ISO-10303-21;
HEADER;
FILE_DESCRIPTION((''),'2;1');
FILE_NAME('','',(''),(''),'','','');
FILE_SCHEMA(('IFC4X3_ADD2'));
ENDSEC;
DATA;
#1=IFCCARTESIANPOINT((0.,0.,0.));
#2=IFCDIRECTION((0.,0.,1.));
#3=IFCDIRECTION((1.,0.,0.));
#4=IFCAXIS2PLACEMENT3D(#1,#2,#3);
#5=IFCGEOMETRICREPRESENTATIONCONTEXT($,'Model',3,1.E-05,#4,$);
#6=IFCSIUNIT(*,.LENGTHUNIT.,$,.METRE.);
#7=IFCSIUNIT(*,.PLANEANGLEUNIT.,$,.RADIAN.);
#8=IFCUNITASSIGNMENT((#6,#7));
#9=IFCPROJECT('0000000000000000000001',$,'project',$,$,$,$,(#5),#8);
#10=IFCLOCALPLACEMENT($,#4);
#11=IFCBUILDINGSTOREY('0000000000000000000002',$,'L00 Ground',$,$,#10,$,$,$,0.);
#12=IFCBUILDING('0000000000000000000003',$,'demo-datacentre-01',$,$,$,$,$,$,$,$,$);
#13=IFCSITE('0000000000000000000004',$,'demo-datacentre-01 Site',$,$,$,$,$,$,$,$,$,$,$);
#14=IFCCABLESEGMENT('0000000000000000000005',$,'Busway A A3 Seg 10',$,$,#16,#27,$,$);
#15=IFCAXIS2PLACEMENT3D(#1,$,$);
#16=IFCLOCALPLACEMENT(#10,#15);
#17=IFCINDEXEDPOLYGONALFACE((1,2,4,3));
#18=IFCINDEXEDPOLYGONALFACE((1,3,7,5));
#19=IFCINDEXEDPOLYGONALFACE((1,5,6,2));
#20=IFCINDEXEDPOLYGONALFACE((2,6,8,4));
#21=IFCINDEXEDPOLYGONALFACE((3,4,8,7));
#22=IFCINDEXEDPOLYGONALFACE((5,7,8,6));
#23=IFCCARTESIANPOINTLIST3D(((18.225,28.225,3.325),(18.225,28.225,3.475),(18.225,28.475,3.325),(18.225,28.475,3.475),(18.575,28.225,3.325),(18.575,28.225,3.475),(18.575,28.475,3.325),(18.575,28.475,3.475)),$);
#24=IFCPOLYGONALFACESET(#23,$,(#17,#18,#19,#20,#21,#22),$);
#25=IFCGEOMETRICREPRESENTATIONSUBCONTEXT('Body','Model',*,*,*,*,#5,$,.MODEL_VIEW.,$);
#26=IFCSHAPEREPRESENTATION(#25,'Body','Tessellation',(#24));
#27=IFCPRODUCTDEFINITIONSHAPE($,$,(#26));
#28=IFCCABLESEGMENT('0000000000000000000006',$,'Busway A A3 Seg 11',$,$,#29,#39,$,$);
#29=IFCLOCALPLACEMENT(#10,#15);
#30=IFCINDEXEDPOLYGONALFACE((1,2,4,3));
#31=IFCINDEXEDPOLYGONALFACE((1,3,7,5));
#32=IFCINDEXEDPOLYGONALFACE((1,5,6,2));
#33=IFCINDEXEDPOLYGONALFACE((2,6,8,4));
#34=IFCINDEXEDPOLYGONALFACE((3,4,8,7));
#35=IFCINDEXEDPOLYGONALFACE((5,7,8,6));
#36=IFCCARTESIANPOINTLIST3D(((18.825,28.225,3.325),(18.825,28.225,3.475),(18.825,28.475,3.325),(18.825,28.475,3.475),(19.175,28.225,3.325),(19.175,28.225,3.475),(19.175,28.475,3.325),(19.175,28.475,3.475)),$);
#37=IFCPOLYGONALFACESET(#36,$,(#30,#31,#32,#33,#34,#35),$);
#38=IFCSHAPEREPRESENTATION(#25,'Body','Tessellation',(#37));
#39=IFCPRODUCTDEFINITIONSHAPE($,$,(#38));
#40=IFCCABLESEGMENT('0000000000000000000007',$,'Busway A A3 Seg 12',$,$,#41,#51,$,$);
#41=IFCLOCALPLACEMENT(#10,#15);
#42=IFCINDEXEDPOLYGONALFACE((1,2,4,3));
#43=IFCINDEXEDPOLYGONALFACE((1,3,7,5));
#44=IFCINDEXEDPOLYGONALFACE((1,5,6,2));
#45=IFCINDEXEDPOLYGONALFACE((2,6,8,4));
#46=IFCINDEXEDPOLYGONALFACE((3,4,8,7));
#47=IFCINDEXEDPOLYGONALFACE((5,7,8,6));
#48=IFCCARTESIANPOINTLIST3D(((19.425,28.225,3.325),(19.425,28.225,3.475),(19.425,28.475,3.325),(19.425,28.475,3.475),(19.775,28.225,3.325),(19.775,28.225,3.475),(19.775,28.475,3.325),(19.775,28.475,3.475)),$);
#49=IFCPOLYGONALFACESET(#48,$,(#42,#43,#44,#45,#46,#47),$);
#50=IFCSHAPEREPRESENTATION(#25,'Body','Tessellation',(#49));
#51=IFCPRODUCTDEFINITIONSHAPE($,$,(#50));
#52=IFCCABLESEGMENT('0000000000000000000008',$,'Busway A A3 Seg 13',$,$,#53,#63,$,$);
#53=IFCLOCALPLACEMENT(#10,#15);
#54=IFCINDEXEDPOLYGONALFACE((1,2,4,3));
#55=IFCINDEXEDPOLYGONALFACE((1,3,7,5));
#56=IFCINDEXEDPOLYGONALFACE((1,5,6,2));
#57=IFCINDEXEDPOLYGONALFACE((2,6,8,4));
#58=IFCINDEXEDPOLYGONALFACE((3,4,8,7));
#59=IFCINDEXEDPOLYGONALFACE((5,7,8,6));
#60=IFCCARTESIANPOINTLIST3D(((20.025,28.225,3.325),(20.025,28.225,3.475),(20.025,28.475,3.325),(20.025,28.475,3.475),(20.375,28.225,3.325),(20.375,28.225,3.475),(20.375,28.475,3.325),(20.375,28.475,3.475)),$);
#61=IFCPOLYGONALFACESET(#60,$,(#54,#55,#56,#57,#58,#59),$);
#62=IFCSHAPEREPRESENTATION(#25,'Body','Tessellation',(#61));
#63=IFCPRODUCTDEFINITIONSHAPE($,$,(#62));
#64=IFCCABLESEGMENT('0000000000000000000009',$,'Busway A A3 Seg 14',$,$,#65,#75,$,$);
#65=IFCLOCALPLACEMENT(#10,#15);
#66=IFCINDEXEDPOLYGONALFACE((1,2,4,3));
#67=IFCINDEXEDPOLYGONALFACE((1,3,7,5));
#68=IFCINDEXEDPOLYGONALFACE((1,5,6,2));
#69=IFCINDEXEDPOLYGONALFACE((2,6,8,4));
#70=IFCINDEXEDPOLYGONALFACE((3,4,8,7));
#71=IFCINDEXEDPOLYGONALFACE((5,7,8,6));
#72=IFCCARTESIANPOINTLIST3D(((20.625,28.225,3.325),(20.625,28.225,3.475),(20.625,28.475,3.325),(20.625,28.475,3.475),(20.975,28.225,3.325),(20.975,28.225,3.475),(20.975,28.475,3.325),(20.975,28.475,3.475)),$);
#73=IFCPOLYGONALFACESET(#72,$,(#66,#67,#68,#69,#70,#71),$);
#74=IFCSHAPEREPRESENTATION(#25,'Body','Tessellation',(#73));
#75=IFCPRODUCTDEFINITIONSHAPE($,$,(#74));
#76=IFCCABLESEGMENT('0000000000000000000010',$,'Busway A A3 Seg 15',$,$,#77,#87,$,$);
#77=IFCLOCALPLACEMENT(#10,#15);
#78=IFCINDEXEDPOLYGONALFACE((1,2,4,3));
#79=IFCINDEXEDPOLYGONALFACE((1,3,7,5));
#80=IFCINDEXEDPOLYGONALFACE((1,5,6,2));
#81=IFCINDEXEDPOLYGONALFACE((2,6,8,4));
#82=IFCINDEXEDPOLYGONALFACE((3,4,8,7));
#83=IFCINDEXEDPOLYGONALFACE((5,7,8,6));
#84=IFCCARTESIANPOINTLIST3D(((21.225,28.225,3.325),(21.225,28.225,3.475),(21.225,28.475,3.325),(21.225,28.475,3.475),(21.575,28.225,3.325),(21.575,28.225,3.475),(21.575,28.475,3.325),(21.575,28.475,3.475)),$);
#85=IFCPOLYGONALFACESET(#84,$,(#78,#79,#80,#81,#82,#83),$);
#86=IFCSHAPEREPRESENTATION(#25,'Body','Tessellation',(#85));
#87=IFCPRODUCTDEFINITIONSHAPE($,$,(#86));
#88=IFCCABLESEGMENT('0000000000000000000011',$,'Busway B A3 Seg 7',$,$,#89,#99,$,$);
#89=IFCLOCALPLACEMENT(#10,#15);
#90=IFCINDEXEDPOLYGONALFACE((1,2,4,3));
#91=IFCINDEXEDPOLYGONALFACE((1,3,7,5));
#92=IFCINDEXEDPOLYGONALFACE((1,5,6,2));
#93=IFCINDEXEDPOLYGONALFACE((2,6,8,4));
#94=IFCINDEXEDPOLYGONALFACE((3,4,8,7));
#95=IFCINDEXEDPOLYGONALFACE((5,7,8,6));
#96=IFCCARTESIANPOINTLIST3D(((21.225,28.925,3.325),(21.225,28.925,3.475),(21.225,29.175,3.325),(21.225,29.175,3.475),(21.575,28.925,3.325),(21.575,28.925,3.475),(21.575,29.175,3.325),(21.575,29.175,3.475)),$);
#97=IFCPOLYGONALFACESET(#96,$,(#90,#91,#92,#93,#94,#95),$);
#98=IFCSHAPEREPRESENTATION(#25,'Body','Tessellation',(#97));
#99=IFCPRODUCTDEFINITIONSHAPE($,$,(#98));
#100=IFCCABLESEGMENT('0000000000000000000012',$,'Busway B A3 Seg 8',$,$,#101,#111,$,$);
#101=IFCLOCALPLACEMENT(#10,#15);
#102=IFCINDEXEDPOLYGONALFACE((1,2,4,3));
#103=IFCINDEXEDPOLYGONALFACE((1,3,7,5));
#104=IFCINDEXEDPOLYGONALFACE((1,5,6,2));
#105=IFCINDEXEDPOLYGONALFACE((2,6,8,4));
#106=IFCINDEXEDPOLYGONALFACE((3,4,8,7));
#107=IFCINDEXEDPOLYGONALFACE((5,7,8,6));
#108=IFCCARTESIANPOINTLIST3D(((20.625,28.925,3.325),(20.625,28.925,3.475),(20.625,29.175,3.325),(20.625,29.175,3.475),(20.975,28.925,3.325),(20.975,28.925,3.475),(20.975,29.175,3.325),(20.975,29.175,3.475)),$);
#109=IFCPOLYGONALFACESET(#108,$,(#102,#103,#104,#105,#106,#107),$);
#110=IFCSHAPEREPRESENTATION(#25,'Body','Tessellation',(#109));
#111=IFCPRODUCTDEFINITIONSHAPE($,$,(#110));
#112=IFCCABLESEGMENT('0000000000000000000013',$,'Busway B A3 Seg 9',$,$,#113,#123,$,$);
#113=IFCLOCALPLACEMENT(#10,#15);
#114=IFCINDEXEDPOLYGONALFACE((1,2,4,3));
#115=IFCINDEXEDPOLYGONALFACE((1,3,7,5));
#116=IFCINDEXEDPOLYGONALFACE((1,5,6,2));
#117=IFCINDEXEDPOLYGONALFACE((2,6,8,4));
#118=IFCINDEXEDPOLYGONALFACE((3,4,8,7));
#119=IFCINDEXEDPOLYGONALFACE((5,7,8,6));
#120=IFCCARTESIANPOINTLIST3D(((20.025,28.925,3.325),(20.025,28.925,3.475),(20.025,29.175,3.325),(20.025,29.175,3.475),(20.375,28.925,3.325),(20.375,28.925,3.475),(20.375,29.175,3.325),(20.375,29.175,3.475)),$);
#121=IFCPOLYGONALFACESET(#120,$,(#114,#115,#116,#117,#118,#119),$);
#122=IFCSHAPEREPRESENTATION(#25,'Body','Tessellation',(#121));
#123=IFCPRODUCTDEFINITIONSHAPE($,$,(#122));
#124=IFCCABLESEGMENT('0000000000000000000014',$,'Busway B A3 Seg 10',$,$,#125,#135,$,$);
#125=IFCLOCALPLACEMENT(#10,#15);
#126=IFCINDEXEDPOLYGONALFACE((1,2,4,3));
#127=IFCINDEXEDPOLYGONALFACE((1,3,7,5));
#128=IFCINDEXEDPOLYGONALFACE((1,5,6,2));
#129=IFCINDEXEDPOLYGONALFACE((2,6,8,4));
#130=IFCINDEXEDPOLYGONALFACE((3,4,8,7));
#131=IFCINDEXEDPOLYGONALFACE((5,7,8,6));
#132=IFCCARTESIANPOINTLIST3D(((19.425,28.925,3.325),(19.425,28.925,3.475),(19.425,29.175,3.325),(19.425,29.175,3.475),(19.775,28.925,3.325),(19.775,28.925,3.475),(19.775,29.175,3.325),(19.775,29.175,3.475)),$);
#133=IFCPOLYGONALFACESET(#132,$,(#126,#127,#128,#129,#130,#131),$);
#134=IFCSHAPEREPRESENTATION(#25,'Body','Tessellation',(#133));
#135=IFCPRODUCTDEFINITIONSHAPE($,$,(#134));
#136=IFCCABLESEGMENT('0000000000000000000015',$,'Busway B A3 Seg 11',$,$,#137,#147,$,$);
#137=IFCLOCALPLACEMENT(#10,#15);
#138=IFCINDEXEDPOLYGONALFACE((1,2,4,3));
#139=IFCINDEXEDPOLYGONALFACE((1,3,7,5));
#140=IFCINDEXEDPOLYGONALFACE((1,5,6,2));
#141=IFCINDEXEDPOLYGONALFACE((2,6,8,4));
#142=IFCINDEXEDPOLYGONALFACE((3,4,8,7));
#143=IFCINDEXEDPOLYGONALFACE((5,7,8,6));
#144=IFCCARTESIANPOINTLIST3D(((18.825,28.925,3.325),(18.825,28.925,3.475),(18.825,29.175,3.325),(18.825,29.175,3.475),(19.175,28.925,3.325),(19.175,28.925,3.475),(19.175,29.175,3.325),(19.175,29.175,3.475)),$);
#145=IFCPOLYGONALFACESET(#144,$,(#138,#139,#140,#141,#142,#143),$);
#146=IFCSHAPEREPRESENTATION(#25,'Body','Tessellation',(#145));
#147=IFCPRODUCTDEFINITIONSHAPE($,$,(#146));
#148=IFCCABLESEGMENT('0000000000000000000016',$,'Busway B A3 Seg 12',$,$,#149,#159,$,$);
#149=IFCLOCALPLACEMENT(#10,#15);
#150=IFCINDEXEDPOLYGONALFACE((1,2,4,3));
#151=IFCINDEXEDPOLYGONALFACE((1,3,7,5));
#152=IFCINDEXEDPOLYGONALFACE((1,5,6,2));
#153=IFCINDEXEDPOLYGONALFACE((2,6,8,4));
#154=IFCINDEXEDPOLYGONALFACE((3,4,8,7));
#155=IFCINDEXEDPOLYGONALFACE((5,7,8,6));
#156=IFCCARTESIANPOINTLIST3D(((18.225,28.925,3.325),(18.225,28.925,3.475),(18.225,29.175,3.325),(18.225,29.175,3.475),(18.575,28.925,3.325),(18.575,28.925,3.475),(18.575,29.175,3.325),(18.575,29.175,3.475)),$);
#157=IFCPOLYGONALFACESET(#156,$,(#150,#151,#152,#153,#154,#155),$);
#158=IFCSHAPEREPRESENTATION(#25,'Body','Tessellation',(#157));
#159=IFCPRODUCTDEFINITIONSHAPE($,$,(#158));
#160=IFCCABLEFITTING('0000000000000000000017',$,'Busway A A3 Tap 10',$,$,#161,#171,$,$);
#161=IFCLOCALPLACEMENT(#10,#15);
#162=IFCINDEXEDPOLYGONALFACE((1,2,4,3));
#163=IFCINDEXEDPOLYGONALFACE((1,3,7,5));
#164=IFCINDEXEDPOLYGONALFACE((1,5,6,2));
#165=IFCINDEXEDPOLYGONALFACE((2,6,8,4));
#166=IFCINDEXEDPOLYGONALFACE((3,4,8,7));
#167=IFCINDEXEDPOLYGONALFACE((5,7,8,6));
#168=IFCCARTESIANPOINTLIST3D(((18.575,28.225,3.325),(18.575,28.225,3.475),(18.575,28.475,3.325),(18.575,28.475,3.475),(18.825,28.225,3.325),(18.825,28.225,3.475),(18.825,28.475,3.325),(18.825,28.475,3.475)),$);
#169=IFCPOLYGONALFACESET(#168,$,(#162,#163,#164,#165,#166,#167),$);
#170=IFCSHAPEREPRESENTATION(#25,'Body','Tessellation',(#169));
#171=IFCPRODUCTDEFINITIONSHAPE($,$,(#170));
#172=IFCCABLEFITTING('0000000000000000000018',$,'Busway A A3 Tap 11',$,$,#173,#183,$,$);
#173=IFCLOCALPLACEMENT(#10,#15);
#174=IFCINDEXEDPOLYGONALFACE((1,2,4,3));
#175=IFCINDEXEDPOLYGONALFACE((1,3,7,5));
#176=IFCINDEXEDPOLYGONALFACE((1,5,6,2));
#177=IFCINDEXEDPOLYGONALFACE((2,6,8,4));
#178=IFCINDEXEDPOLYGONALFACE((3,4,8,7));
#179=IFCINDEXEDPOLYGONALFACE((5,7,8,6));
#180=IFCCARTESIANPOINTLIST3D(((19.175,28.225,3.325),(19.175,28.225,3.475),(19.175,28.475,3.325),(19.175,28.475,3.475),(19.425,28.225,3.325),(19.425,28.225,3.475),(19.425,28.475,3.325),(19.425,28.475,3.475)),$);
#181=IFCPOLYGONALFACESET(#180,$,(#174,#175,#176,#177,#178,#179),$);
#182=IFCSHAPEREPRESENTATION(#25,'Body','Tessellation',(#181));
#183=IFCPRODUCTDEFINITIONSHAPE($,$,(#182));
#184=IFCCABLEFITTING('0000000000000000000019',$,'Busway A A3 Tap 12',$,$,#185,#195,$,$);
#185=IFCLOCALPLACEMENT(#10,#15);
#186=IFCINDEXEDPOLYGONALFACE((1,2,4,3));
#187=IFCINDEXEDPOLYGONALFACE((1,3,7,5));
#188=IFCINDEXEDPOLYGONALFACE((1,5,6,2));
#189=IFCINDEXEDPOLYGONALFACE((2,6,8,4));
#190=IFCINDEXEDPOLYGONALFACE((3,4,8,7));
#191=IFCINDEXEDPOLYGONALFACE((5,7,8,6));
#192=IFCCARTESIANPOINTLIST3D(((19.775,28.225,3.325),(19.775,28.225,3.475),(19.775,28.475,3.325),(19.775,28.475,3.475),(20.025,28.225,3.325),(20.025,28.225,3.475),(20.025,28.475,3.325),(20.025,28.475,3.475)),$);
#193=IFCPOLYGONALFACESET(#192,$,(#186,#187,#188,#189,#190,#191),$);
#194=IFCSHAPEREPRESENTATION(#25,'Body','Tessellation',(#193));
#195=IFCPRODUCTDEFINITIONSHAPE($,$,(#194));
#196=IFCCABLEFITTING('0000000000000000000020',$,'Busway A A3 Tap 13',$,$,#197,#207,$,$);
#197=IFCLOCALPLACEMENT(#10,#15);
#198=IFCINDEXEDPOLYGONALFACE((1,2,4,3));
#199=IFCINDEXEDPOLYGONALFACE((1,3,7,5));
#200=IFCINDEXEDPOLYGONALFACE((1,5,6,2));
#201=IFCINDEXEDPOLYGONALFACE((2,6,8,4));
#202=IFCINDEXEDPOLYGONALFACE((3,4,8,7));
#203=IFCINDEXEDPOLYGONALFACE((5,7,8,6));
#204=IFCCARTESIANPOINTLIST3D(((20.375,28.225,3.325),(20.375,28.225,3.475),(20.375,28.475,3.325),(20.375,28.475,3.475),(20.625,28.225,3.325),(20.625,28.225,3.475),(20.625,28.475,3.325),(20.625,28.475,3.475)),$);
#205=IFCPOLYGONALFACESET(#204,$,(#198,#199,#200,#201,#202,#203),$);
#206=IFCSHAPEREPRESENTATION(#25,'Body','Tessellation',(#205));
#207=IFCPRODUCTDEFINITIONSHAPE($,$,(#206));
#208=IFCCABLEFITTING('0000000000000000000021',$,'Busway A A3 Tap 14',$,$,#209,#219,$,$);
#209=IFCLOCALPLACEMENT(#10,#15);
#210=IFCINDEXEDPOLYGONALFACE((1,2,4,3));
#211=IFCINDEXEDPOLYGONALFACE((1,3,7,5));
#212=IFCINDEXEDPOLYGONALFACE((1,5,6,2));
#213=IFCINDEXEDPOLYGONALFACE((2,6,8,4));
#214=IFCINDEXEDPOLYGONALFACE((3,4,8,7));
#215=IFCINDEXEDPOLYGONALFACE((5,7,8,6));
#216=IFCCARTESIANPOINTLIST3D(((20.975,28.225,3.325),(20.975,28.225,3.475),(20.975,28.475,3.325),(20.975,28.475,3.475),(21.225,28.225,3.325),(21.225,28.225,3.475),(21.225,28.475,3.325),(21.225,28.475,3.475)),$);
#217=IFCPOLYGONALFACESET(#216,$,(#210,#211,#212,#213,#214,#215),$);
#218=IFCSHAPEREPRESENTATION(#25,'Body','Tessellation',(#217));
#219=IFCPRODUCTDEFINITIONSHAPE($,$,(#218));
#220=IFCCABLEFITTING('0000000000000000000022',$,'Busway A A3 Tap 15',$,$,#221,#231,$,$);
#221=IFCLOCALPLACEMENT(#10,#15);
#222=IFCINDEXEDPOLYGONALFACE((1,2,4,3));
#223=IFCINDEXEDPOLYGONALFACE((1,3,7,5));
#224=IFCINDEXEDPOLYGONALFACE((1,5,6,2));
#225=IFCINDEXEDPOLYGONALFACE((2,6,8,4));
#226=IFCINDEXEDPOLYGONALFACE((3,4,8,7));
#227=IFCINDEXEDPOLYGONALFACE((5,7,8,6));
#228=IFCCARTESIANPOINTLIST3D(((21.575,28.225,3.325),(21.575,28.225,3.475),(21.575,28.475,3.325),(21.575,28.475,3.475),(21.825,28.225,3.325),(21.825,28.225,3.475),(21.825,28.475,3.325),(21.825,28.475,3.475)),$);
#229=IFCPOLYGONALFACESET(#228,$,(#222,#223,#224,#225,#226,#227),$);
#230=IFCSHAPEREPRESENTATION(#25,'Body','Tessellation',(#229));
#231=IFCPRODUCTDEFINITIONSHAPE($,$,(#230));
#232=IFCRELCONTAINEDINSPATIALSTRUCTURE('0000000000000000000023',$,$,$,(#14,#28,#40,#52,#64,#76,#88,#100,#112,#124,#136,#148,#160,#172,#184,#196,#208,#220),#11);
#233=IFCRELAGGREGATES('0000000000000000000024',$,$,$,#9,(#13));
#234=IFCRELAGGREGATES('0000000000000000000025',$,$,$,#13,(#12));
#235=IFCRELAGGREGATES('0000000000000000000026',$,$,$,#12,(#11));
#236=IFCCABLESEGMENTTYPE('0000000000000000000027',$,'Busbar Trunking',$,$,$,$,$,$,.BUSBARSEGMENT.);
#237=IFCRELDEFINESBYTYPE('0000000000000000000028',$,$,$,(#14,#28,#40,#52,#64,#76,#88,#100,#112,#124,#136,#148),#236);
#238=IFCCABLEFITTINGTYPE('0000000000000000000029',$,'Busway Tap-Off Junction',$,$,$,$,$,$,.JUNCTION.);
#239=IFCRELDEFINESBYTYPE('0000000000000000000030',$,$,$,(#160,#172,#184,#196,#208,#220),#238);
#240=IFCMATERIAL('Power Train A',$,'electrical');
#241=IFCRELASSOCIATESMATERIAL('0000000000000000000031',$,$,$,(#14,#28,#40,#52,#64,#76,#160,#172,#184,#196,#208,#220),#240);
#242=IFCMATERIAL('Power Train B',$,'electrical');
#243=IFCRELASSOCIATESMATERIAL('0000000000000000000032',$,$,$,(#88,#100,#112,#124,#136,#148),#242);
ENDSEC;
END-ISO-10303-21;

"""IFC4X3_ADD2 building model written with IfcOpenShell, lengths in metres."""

from ifc_helpers import new_model, si_unit, frame, origin_with_axes, place, context, subcontext, project, spatial, rectangle, extrude, material, type_object, element, save


model = new_model("IFC4X3_ADD2")

# Units and contexts
model_context = context("Model", 3, precision=1e-05, world=origin_with_axes())
body_context = subcontext(model_context, "Body", "Model", "MODEL_VIEW")
ifc_project = project(units=[si_unit("LENGTHUNIT", "METRE"), si_unit("PLANEANGLEUNIT", "RADIAN")], contexts=[model_context])

# Site, building, storey
site = spatial("IfcSite", under=ifc_project, Name="demo-datacentre-01 Site")
building = spatial("IfcBuilding", under=site, Name="demo-datacentre-01")
storey_placement = place(None, origin_with_axes())
storey = spatial("IfcBuildingStorey", under=building, at=storey_placement, Name="L00 Ground", Elevation=0.0)

# Cable segments
ifc_material_1 = material(Name="Power Train A", Category="electrical")
cable_segment_type_1 = type_object("IfcCableSegmentType", Name="Busbar Trunking", PredefinedType="BUSBARSEGMENT")
cable_segment_1_placement = place(storey_placement, frame((18.225, 28.35, 3.4), z_axis=(1.0, 0.0, 0.0), x_axis=(0.0, 1.0, 0.0)))
element("IfcCableSegment", 1, at=cable_segment_1_placement, inside=storey, type_object=cable_segment_type_1, material=ifc_material_1, Name="Busway A A3 Seg 10", context=body_context, shape_type="SweptSolid", body=[
    extrude(rectangle(XDim=0.25, YDim=0.15), origin_with_axes(), (0.0, 0.0, 1.0), 0.35),
])
cable_segment_2_placement = place(storey_placement, frame((18.825, 28.35, 3.4), z_axis=(1.0, 0.0, 0.0), x_axis=(0.0, 1.0, 0.0)))
element("IfcCableSegment", 2, at=cable_segment_2_placement, inside=storey, type_object=cable_segment_type_1, material=ifc_material_1, Name="Busway A A3 Seg 11", context=body_context, shape_type="SweptSolid", body=[
    extrude(rectangle(XDim=0.25, YDim=0.15), origin_with_axes(), (0.0, 0.0, 1.0), 0.35),
])
cable_segment_3_placement = place(storey_placement, frame((19.425, 28.35, 3.4), z_axis=(1.0, 0.0, 0.0), x_axis=(0.0, 1.0, 0.0)))
element("IfcCableSegment", 3, at=cable_segment_3_placement, inside=storey, type_object=cable_segment_type_1, material=ifc_material_1, Name="Busway A A3 Seg 12", context=body_context, shape_type="SweptSolid", body=[
    extrude(rectangle(XDim=0.25, YDim=0.15), origin_with_axes(), (0.0, 0.0, 1.0), 0.35),
])
for number, where, z_axis, x_axis, name in (
    (4, (20.025, 28.35, 3.4), (1.0, 0.0, 0.0), (0.0, 1.0, 0.0), "Busway A A3 Seg 13"),
    (5, (20.625, 28.35, 3.4), (1.0, 0.0, 0.0), (0.0, 1.0, 0.0), "Busway A A3 Seg 14"),
    (6, (21.225, 28.35, 3.4), (1.0, 0.0, 0.0), (0.0, 1.0, 0.0), "Busway A A3 Seg 15"),
):
    element("IfcCableSegment", number, at=place(storey_placement, frame(where, z_axis=z_axis, x_axis=x_axis)), inside=storey, type_object=cable_segment_type_1, material=ifc_material_1, Name=name, context=body_context, shape_type="SweptSolid", body=[
        extrude(rectangle(XDim=0.25, YDim=0.15), origin_with_axes(), (0.0, 0.0, 1.0), 0.35),
    ])
ifc_material_2 = material(Name="Power Train B", Category="electrical")
for number, where, z_axis, x_axis, name in (
    (7, (21.575, 29.05, 3.4), (-1.0, 0.0, 0.0), (0.0, -1.0, 0.0), "Busway B A3 Seg 7"),
    (8, (20.975, 29.05, 3.4), (-1.0, 0.0, 0.0), (0.0, -1.0, 0.0), "Busway B A3 Seg 8"),
    (9, (20.375, 29.05, 3.4), (-1.0, 0.0, 0.0), (0.0, -1.0, 0.0), "Busway B A3 Seg 9"),
):
    element("IfcCableSegment", number, at=place(storey_placement, frame(where, z_axis=z_axis, x_axis=x_axis)), inside=storey, type_object=cable_segment_type_1, material=ifc_material_2, Name=name, context=body_context, shape_type="SweptSolid", body=[
        extrude(rectangle(XDim=0.25, YDim=0.15), origin_with_axes(), (0.0, 0.0, 1.0), 0.35),
    ])
cable_segment_4_placement = place(storey_placement, frame((19.775, 29.05, 3.4), z_axis=(-1.0, 0.0, 0.0), x_axis=(0.0, -1.0, 0.0)))
element("IfcCableSegment", 10, at=cable_segment_4_placement, inside=storey, type_object=cable_segment_type_1, material=ifc_material_2, Name="Busway B A3 Seg 10", context=body_context, shape_type="SweptSolid", body=[
    extrude(rectangle(XDim=0.25, YDim=0.15), origin_with_axes(), (0.0, 0.0, 1.0), 0.35),
])
cable_segment_5_placement = place(storey_placement, frame((19.175, 29.05, 3.4), z_axis=(-1.0, 0.0, 0.0), x_axis=(0.0, -1.0, 0.0)))
element("IfcCableSegment", 11, at=cable_segment_5_placement, inside=storey, type_object=cable_segment_type_1, material=ifc_material_2, Name="Busway B A3 Seg 11", context=body_context, shape_type="SweptSolid", body=[
    extrude(rectangle(XDim=0.25, YDim=0.15), origin_with_axes(), (0.0, 0.0, 1.0), 0.35),
])
cable_segment_6_placement = place(storey_placement, frame((18.575, 29.05, 3.4), z_axis=(-1.0, 0.0, 0.0), x_axis=(0.0, -1.0, 0.0)))
element("IfcCableSegment", 12, at=cable_segment_6_placement, inside=storey, type_object=cable_segment_type_1, material=ifc_material_2, Name="Busway B A3 Seg 12", context=body_context, shape_type="SweptSolid", body=[
    extrude(rectangle(XDim=0.25, YDim=0.15), origin_with_axes(), (0.0, 0.0, 1.0), 0.35),
])

# Cable fittings
cable_fitting_type = type_object("IfcCableFittingType", Name="Busway Tap-Off Junction", PredefinedType="JUNCTION")
for number, where, z_axis, x_axis, name in (
    (13, (18.7, 28.35, 3.325), (0.0, 0.0, 1.0), (1.0, 0.0, 0.0), "Busway A A3 Tap 10"),
    (14, (19.3, 28.35, 3.325), (0.0, 0.0, 1.0), (1.0, 0.0, 0.0), "Busway A A3 Tap 11"),
    (15, (19.9, 28.35, 3.325), (0.0, 0.0, 1.0), (1.0, 0.0, 0.0), "Busway A A3 Tap 12"),
    (16, (20.5, 28.35, 3.325), (0.0, 0.0, 1.0), (1.0, 0.0, 0.0), "Busway A A3 Tap 13"),
    (17, (21.1, 28.35, 3.325), (0.0, 0.0, 1.0), (1.0, 0.0, 0.0), "Busway A A3 Tap 14"),
    (18, (21.7, 28.35, 3.325), (0.0, 0.0, 1.0), (1.0, 0.0, 0.0), "Busway A A3 Tap 15"),
):
    element("IfcCableFitting", number, at=place(storey_placement, frame(where, z_axis=z_axis, x_axis=x_axis)), inside=storey, type_object=cable_fitting_type, material=ifc_material_1, Name=name, context=body_context, shape_type="SweptSolid", body=[
        extrude(rectangle(XDim=0.25, YDim=0.25), origin_with_axes(), (0.0, 0.0, 1.0), 0.15),
    ])

save(model, "model.ifc")
